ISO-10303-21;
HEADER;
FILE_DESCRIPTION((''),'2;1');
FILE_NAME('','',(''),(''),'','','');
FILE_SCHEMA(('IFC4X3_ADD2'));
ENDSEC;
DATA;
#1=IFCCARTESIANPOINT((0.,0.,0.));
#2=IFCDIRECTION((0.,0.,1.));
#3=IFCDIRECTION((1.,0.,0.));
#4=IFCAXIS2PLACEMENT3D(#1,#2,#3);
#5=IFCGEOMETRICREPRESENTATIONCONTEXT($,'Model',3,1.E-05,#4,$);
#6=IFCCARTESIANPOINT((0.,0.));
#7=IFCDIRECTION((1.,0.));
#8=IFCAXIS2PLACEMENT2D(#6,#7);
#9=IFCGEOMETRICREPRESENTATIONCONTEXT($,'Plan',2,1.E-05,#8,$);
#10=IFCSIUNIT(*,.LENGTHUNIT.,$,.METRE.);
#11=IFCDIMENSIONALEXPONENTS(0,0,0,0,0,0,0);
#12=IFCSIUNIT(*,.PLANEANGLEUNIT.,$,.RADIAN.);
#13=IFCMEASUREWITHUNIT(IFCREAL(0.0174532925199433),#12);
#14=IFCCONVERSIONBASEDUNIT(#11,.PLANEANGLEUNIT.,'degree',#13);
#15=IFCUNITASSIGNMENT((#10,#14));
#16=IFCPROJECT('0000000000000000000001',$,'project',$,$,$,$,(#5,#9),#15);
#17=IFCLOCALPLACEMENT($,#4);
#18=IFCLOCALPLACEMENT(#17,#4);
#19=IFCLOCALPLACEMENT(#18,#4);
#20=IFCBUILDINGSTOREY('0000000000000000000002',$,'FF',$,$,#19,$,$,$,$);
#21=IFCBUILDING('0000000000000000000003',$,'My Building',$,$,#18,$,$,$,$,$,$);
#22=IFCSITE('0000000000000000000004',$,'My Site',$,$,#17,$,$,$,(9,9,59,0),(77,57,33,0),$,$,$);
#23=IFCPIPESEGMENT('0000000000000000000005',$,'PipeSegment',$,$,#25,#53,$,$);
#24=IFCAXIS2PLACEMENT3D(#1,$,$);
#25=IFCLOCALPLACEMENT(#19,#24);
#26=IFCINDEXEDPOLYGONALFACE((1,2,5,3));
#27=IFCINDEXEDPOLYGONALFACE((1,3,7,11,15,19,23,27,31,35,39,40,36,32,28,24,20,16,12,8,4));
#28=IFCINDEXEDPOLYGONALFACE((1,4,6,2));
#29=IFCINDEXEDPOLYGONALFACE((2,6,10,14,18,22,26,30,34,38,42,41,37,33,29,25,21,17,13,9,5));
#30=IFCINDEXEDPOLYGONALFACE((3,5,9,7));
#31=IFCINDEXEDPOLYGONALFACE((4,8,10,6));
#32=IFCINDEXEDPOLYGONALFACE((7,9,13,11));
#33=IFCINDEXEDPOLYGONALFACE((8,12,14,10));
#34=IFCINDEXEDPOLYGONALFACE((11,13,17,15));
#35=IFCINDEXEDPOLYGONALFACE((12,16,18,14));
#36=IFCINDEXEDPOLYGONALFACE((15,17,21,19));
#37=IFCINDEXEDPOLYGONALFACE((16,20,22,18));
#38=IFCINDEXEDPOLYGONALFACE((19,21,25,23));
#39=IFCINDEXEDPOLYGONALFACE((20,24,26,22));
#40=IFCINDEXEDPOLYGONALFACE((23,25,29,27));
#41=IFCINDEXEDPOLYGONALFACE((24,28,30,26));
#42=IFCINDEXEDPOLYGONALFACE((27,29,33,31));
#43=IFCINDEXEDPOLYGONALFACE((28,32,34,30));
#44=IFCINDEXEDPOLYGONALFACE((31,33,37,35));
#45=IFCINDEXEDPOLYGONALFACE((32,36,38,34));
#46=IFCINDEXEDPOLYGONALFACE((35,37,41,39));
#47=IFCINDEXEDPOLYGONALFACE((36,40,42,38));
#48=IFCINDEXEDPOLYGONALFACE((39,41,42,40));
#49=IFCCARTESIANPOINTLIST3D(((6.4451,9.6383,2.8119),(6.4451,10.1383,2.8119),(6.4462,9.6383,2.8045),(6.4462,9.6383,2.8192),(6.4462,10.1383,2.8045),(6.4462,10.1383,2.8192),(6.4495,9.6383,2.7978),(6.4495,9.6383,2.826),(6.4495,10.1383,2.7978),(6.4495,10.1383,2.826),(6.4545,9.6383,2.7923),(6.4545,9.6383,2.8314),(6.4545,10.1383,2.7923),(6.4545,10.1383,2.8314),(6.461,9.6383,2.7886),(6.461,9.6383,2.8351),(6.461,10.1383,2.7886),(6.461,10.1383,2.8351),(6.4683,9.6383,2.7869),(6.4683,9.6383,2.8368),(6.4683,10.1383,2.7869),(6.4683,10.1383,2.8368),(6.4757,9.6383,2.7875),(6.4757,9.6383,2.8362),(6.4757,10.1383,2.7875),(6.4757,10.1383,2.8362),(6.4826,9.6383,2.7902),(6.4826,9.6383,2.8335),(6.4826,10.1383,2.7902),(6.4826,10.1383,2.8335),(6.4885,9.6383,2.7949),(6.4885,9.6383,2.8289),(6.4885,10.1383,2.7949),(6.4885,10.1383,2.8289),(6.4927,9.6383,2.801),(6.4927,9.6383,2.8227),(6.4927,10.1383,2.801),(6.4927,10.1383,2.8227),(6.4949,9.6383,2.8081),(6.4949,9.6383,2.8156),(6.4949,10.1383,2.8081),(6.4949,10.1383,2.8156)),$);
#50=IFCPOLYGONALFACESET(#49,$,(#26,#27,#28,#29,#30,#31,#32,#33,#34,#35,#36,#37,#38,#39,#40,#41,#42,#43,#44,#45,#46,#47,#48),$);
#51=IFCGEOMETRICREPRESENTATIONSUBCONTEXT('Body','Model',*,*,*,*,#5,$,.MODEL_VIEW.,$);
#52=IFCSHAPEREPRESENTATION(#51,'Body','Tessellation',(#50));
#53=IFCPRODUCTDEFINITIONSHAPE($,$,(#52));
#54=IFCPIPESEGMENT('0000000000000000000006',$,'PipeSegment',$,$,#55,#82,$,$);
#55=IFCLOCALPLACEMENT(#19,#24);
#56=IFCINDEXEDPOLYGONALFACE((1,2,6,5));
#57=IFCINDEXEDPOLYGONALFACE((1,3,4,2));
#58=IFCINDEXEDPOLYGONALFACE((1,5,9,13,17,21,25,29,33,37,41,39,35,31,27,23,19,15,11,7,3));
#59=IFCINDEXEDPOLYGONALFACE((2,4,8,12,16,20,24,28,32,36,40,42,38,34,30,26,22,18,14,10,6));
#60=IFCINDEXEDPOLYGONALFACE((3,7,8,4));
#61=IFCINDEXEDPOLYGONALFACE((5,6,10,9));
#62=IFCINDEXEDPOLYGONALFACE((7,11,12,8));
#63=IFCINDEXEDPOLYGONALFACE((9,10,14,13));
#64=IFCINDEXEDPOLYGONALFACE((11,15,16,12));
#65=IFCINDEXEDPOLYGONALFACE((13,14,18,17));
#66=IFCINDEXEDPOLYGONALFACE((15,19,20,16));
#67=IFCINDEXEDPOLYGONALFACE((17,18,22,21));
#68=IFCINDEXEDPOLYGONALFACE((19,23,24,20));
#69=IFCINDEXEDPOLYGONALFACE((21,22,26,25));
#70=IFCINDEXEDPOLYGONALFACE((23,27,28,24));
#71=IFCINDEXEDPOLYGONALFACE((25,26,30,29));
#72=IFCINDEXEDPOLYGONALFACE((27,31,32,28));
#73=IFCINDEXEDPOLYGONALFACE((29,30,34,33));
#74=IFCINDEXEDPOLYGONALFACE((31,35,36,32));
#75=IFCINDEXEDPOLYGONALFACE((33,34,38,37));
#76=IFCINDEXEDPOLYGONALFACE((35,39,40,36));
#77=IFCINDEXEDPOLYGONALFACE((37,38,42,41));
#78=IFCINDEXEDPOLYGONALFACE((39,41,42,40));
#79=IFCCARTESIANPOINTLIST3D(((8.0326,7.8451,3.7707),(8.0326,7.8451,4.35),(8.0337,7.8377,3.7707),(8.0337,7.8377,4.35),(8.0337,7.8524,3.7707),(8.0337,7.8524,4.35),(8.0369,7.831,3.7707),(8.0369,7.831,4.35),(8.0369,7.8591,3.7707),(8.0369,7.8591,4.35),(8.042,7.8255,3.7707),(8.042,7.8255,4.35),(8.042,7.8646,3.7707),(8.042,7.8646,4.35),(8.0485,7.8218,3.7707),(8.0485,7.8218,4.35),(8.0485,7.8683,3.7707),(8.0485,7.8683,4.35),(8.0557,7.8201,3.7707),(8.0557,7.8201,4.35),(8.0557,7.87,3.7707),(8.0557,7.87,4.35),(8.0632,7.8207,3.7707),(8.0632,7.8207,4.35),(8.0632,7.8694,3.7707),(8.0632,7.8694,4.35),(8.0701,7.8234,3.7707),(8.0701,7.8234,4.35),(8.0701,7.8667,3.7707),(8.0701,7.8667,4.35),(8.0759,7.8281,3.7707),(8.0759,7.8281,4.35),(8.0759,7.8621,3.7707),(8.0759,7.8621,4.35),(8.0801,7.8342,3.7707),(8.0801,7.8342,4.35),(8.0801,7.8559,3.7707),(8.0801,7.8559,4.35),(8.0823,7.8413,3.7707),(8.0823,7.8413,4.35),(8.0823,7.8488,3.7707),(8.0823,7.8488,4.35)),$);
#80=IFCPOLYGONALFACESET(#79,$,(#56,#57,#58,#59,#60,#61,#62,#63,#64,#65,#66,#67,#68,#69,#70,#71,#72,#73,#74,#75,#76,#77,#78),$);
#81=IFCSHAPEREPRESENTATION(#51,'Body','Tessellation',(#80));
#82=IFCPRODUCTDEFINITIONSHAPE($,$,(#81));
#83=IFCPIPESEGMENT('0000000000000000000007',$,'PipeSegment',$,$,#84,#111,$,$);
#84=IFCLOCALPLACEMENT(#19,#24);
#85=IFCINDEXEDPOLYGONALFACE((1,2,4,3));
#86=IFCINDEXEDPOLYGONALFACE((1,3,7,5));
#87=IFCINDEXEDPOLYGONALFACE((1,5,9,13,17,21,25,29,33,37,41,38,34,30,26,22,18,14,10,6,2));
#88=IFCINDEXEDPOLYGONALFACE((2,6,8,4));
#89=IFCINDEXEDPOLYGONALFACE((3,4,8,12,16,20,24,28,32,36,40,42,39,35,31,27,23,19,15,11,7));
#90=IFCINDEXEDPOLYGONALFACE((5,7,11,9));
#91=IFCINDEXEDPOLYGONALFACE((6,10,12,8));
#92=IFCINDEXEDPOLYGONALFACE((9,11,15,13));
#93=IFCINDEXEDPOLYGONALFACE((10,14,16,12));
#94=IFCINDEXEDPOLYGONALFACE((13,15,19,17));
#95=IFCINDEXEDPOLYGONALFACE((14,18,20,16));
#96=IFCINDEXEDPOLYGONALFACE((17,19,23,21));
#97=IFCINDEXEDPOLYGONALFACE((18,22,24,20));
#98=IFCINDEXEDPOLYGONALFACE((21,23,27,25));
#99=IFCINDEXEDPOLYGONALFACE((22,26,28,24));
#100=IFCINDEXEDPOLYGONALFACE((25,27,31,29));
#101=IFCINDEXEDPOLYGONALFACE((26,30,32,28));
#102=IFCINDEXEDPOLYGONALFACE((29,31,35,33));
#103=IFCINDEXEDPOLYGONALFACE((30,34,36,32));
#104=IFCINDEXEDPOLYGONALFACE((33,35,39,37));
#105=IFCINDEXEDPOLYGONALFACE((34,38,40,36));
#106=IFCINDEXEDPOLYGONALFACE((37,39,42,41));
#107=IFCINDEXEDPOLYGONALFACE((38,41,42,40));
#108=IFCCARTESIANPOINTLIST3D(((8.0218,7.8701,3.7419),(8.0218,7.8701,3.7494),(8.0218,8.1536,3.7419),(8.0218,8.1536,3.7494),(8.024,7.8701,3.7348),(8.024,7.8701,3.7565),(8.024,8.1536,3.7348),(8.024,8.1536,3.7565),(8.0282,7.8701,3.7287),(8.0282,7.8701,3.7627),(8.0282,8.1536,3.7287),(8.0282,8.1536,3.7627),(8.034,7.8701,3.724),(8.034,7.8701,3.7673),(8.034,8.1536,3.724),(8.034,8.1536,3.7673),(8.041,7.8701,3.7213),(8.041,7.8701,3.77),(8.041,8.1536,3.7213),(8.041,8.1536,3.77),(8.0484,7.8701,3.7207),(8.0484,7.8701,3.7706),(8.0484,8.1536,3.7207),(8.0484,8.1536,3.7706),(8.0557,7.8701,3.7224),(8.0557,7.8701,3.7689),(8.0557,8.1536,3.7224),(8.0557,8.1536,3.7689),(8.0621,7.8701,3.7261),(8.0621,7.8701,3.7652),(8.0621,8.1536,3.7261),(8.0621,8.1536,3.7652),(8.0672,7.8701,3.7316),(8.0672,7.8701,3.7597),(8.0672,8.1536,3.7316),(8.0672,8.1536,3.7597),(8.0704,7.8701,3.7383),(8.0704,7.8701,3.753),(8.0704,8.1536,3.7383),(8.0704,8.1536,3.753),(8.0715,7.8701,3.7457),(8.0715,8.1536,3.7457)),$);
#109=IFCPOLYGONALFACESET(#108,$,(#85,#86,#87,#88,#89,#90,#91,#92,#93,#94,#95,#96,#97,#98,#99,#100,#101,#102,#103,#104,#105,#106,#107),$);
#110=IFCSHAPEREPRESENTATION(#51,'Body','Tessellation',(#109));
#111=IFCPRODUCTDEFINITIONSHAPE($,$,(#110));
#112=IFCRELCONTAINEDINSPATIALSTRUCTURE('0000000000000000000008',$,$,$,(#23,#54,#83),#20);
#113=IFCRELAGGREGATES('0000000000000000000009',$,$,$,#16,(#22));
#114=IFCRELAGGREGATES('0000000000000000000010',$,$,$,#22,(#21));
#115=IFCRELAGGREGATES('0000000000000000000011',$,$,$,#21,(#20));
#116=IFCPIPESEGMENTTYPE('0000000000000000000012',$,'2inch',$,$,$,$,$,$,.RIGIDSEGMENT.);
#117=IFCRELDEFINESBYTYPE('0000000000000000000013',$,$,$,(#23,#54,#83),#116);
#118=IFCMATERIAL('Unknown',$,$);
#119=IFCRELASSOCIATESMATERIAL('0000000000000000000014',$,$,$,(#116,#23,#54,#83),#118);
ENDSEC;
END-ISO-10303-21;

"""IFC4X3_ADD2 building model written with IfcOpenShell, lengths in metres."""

from ifc_helpers import new_model, entity, si_unit, converted_unit, frame, origin_with_axes, origin_2d_with_axis, place, context, subcontext, project, spatial, circle, extrude, material, material_profile, profile_set, profile_usage, type_object, element, save


model = new_model("IFC4X3_ADD2")

# Units and contexts
model_context = context("Model", 3, precision=1e-05, world=origin_with_axes())
plan_context = context("Plan", 2, precision=1e-05, world=origin_2d_with_axis())
body_context_1 = subcontext(model_context, "Body", "Model", "MODEL_VIEW")
ifc_project = project(units=[si_unit("LENGTHUNIT", "METRE"), converted_unit("PLANEANGLEUNIT", "degree", entity("IfcReal", 0.0174532925199433), si_unit("PLANEANGLEUNIT", "RADIAN"), dimensions=[0, 0, 0, 0, 0, 0, 0])], contexts=[model_context, plan_context])

# Site, building, storey
site_placement = place(None, origin_with_axes())
site = spatial("IfcSite", under=ifc_project, at=site_placement, Name="My Site", RefLatitude=(9, 9, 59, 0), RefLongitude=(77, 57, 33, 0))
building_placement = place(site_placement, origin_with_axes())
building = spatial("IfcBuilding", under=site, at=building_placement, Name="My Building")
storey_placement = place(building_placement, origin_with_axes())
storey = spatial("IfcBuildingStorey", under=building, at=storey_placement, Name="FF")

# Shared definitions
ifc_material = material(Name="Unknown")

# Pipe segments
ifc_material_profile_1 = material_profile(ifc_material, circle(Radius=0.025))
ifc_profile_set_1 = profile_set([ifc_material_profile_1])
pipe_segment_type = type_object("IfcPipeSegmentType", Name="2inch", PredefinedType="RIGIDSEGMENT", material=ifc_profile_set_1)
ifc_profile_usage_1 = profile_usage(ifc_profile_set_1)
pipe_segment_1_placement = place(storey_placement, frame((6.4701, 9.6383, 2.8119), z_axis=(0.0, 1.0, 0.0), x_axis=(-1.0, 0.0, 0.0)))
element("IfcPipeSegment", 1, at=pipe_segment_1_placement, inside=storey, type_object=pipe_segment_type, material=ifc_profile_usage_1, Name="PipeSegment", context=body_context_1, shape_type="SweptSolid", body=[
    extrude(circle(Radius=0.025), origin_with_axes(), (0.0, 0.0, 1.0), 0.5),
])
ifc_profile_usage_2 = profile_usage(ifc_profile_set_1)
pipe_segment_2_placement = place(storey_placement, frame((8.0576, 7.8451, 3.7707), z_axis=(0.0, 0.0, 1.0), x_axis=(-1.0, 0.0, 0.0)))
element("IfcPipeSegment", 2, at=pipe_segment_2_placement, inside=storey, type_object=pipe_segment_type, material=ifc_profile_usage_2, Name="PipeSegment", context=body_context_1, shape_type="SweptSolid", body=[
    extrude(circle(Radius=0.025), origin_with_axes(), (0.0, 0.0, 1.0), 0.5793),
])
ifc_profile_usage_3 = profile_usage(ifc_profile_set_1)
pipe_segment_3_placement = place(storey_placement, frame((8.0465, 8.1536, 3.7457), z_axis=(0.0, -1.0, 0.0), x_axis=(1.0, 0.0, 0.0)))
element("IfcPipeSegment", 3, at=pipe_segment_3_placement, inside=storey, type_object=pipe_segment_type, material=ifc_profile_usage_3, Name="PipeSegment", context=body_context_1, shape_type="SweptSolid", body=[
    extrude(circle(Radius=0.025), origin_with_axes(), (0.0, 0.0, 1.0), 0.2835),
])

save(model, "model.ifc")
